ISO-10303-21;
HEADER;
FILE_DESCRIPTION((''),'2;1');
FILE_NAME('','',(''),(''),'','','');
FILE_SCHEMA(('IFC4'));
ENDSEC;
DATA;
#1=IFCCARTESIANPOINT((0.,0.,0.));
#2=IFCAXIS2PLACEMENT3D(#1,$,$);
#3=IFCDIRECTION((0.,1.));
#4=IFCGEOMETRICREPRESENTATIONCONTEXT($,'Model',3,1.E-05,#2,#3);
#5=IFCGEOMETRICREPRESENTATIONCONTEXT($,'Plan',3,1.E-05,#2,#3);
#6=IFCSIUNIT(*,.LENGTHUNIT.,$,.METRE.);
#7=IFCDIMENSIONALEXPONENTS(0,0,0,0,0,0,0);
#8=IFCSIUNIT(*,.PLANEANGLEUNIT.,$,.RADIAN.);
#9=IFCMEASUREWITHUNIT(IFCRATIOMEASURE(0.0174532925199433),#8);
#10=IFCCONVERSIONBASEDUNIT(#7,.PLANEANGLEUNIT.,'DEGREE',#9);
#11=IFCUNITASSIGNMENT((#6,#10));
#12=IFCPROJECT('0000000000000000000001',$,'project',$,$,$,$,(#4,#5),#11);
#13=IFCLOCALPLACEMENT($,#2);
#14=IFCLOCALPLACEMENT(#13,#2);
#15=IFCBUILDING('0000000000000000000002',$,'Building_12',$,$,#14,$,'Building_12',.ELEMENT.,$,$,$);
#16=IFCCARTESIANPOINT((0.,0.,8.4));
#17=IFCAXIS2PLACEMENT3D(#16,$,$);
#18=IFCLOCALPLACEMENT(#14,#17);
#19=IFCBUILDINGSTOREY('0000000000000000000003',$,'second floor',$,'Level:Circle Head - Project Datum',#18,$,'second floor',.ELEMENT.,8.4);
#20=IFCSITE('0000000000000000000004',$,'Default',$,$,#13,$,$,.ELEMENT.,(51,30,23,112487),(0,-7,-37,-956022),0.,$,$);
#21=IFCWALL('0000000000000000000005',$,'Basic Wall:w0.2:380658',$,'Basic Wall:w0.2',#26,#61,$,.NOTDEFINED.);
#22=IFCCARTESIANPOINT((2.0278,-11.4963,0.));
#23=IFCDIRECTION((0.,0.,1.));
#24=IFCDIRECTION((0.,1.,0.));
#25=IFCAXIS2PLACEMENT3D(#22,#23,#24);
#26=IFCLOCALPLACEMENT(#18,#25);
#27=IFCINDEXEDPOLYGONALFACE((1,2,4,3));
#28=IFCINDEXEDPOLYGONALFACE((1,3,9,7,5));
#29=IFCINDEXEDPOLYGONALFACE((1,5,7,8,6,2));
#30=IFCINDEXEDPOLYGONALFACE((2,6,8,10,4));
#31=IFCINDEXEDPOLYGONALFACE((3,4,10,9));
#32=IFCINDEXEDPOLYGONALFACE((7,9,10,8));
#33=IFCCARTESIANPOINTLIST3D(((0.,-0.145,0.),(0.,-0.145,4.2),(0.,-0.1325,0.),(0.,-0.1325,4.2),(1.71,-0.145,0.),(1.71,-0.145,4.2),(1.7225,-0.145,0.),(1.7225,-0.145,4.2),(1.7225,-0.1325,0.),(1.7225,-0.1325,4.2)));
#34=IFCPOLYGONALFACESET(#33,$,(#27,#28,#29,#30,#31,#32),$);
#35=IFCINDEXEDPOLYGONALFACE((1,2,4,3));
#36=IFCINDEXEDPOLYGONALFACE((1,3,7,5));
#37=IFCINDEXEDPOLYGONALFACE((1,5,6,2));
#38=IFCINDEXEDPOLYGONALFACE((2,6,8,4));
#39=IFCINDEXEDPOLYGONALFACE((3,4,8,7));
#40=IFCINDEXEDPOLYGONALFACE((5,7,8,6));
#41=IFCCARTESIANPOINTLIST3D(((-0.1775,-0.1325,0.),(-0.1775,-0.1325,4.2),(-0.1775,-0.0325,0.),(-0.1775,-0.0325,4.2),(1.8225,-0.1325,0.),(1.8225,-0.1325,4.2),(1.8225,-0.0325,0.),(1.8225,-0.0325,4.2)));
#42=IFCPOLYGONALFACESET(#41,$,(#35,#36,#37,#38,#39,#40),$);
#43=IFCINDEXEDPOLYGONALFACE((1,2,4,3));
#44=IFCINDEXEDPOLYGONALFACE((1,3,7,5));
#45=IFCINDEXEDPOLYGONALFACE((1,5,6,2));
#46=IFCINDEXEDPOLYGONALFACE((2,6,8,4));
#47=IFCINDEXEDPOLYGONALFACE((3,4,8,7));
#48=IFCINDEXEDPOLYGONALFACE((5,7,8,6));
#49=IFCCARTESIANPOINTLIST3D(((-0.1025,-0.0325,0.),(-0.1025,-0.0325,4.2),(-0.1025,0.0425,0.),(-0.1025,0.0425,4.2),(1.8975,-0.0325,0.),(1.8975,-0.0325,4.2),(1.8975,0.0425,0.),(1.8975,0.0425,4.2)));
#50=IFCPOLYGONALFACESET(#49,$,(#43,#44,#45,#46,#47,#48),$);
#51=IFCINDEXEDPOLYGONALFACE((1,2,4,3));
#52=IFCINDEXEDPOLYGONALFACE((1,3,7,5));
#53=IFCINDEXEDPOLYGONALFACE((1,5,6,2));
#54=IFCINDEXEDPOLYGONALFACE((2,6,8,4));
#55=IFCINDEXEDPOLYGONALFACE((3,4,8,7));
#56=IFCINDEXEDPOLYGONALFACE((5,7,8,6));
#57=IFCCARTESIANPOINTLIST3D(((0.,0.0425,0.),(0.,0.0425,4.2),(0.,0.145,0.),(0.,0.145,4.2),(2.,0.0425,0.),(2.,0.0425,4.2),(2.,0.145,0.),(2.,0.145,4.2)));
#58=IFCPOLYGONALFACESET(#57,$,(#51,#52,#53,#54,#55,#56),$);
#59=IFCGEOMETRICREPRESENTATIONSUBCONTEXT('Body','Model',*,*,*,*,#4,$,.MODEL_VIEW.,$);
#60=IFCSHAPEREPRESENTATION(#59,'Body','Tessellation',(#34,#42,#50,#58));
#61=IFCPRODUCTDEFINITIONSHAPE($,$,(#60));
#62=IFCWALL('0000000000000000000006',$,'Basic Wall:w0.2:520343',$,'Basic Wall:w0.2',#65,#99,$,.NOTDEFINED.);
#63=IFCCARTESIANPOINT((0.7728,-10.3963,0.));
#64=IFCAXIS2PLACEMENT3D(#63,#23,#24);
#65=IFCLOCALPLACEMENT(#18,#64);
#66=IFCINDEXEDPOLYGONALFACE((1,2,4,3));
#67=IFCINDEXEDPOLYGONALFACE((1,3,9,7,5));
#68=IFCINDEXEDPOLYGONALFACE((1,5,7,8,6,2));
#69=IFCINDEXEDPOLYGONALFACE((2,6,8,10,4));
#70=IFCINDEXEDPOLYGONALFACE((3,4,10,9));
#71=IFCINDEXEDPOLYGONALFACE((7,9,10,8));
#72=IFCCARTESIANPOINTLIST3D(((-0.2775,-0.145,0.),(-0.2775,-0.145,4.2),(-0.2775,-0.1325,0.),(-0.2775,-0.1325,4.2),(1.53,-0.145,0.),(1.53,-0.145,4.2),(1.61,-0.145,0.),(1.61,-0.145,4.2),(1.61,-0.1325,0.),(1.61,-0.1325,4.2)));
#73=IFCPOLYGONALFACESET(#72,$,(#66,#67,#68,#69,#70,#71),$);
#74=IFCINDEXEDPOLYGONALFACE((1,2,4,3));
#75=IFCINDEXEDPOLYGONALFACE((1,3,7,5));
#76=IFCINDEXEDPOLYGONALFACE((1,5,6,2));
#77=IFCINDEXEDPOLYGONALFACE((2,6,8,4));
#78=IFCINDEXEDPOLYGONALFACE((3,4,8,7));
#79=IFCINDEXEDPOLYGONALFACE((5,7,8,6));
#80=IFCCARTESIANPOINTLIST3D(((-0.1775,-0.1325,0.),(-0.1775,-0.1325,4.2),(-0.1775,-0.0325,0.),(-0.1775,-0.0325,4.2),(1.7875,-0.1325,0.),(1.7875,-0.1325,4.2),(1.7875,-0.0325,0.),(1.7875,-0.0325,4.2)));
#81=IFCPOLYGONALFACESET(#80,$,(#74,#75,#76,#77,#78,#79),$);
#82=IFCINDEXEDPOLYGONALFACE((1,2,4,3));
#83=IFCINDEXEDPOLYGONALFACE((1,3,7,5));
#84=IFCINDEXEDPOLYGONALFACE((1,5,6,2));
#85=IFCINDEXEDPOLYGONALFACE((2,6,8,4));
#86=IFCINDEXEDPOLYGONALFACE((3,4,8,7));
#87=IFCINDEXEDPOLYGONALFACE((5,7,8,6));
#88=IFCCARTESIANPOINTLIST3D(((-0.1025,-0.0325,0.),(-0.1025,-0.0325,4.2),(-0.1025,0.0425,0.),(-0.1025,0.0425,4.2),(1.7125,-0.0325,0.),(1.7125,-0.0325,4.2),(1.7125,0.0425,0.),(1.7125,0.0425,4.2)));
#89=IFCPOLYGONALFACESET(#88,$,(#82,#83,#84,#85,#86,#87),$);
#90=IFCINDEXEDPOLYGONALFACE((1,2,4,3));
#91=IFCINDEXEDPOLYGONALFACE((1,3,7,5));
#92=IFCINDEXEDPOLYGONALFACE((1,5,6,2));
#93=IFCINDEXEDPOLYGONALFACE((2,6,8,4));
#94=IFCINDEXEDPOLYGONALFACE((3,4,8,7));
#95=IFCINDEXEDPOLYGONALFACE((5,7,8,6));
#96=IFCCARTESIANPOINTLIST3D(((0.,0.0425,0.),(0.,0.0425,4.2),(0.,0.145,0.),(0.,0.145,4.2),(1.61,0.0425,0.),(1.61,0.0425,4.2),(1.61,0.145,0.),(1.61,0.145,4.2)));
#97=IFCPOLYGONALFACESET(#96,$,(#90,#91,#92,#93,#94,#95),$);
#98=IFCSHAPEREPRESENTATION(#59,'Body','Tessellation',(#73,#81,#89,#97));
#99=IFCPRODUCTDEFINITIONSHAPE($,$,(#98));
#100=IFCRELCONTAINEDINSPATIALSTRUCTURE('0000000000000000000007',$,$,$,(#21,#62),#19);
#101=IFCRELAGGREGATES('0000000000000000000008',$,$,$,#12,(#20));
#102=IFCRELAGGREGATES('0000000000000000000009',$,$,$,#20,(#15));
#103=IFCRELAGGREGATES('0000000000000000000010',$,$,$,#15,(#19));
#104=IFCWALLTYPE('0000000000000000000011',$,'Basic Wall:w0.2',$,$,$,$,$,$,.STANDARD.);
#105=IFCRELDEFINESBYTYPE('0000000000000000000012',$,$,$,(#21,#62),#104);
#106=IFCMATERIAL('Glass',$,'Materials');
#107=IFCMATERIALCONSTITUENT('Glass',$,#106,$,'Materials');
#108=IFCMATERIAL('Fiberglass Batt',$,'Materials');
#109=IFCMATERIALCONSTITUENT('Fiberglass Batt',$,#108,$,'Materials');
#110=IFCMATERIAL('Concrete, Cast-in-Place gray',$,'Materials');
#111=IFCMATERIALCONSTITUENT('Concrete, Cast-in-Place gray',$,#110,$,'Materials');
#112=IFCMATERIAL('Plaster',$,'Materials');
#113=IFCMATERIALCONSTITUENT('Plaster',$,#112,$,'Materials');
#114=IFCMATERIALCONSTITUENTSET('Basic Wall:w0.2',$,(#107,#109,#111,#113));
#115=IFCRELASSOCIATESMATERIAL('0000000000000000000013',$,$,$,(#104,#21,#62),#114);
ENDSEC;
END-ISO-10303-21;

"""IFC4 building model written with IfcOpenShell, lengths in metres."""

from ifc_helpers import new_model, entity, si_unit, converted_unit, direction, frame, origin, place, context, subcontext, project, spatial, indexed_curve, outline, extrude, material, constituent, constituent_set, type_object, element, save


model = new_model("IFC4")

# Units and contexts
model_context = context("Model", 3, precision=1e-05, world=origin(), true_north=direction((0.0, 1.0)))
plan_context = context("Plan", 3, precision=1e-05, world=origin(), true_north=direction((0.0, 1.0)))
body_context = subcontext(model_context, "Body", "Model", "MODEL_VIEW")
ifc_project = project(units=[si_unit("LENGTHUNIT", "METRE"), converted_unit("PLANEANGLEUNIT", "DEGREE", entity("IfcRatioMeasure", 0.0174532925199433), si_unit("PLANEANGLEUNIT", "RADIAN"), dimensions=[0, 0, 0, 0, 0, 0, 0])], contexts=[model_context, plan_context])

# Site, building, storey
site_placement = place(None, origin())
site = spatial("IfcSite", under=ifc_project, at=site_placement, Name="Default", CompositionType="ELEMENT", RefLatitude=(51, 30, 23, 112487), RefLongitude=(0, -7, -37, -956022), RefElevation=0.0)
building_placement = place(site_placement, origin())
building = spatial("IfcBuilding", under=site, at=building_placement, Name="Building_12", LongName="Building_12", CompositionType="ELEMENT")
storey_placement = place(building_placement, frame((0.0, 0.0, 8.4)))
storey = spatial("IfcBuildingStorey", under=building, at=storey_placement, Name="second floor", ObjectType="Level:Circle Head - Project Datum", LongName="second floor", CompositionType="ELEMENT", Elevation=8.4)

# Shared definitions
ifc_material_1 = material(Name="Glass", Category="Materials")
ifc_constituent_1 = constituent(ifc_material_1, Name="Glass", Category="Materials")
ifc_material_2 = material(Name="Fiberglass Batt", Category="Materials")
ifc_constituent_2 = constituent(ifc_material_2, Name="Fiberglass Batt", Category="Materials")
ifc_material_3 = material(Name="Concrete, Cast-in-Place gray", Category="Materials")
ifc_constituent_3 = constituent(ifc_material_3, Name="Concrete, Cast-in-Place gray", Category="Materials")
ifc_material_4 = material(Name="Plaster", Category="Materials")
ifc_constituent_4 = constituent(ifc_material_4, Name="Plaster", Category="Materials")
ifc_constituent_set = constituent_set(constituents=[ifc_constituent_1, ifc_constituent_2, ifc_constituent_3, ifc_constituent_4], Name="Basic Wall:w0.2")
wall_type = type_object("IfcWallType", Name="Basic Wall:w0.2", PredefinedType="STANDARD", material=ifc_constituent_set)

# Wall
wall_1_placement = place(storey_placement, frame((2.0278, -11.4963, 0.0), z_axis=(0.0, 0.0, 1.0), x_axis=(0.0, 1.0, 0.0)))
element("IfcWall", 1, at=wall_1_placement, inside=storey, type_object=wall_type, material=ifc_constituent_set, Name="Basic Wall:w0.2:380658", ObjectType="Basic Wall:w0.2", PredefinedType="NOTDEFINED", context=body_context, shape_type="SweptSolid", body=[
    extrude(outline(indexed_curve([(0.679, -0.005), (0.6915, -0.005), (0.6915, 0.0075), (-1.031, 0.0075), (-1.031, -0.005), (0.679, -0.005)], self_intersect=False)), frame((1.031, -0.14, 0.0)), (0.0, 0.0, 1.0), 4.2),
    extrude(outline(indexed_curve([(-1.0, -0.05), (1.0, -0.05), (1.0, 0.05), (-1.0, 0.05), (-1.0, -0.05)], self_intersect=False)), frame((0.8225, -0.0825, 0.0)), (0.0, 0.0, 1.0), 4.2),
    extrude(outline(indexed_curve([(-1.0, -0.0375), (1.0, -0.0375), (1.0, 0.0375), (-1.0, 0.0375), (-1.0, -0.0375)], self_intersect=False)), frame((0.8975, 0.005, 0.0)), (0.0, 0.0, 1.0), 4.2),
    extrude(outline(indexed_curve([(-0.0513, -1.0), (0.0512, -1.0), (0.0513, 1.0), (-0.0512, 1.0), (-0.0513, -1.0)], self_intersect=False)), frame((1.0, 0.0938, 0.0), z_axis=(0.0, 0.0, 1.0), x_axis=(0.0, -1.0, 0.0)), (0.0, 0.0, 1.0), 4.2),
])

# Wall
wall_2_placement = place(storey_placement, frame((0.7728, -10.3963, 0.0), z_axis=(0.0, 0.0, 1.0), x_axis=(0.0, 1.0, 0.0)))
element("IfcWall", 2, at=wall_2_placement, inside=storey, type_object=wall_type, material=ifc_constituent_set, Name="Basic Wall:w0.2:520343", ObjectType="Basic Wall:w0.2", PredefinedType="NOTDEFINED", context=body_context, shape_type="SweptSolid", body=[
    extrude(outline(indexed_curve([(0.691, -0.005), (0.771, -0.005), (0.771, 0.0075), (-1.1165, 0.0075), (-1.1165, -0.005), (0.691, -0.005)], self_intersect=False)), frame((0.839, -0.14, 0.0)), (0.0, 0.0, 1.0), 4.2),
    extrude(outline(indexed_curve([(-0.9825, -0.05), (0.9825, -0.05), (0.9825, 0.05), (-0.9825, 0.05), (-0.9825, -0.05)], self_intersect=False)), frame((0.805, -0.0825, 0.0)), (0.0, 0.0, 1.0), 4.2),
    extrude(outline(indexed_curve([(-0.9075, -0.0375), (0.9075, -0.0375), (0.9075, 0.0375), (-0.9075, 0.0375), (-0.9075, -0.0375)], self_intersect=False)), frame((0.805, 0.005, 0.0)), (0.0, 0.0, 1.0), 4.2),
    extrude(outline(indexed_curve([(-0.0513, -0.805), (0.0512, -0.805), (0.0513, 0.805), (-0.0512, 0.805), (-0.0513, -0.805)], self_intersect=False)), frame((0.805, 0.0937, 0.0), z_axis=(0.0, 0.0, 1.0), x_axis=(0.0, -1.0, 0.0)), (0.0, 0.0, 1.0), 4.2),
])

save(model, "model.ifc")
